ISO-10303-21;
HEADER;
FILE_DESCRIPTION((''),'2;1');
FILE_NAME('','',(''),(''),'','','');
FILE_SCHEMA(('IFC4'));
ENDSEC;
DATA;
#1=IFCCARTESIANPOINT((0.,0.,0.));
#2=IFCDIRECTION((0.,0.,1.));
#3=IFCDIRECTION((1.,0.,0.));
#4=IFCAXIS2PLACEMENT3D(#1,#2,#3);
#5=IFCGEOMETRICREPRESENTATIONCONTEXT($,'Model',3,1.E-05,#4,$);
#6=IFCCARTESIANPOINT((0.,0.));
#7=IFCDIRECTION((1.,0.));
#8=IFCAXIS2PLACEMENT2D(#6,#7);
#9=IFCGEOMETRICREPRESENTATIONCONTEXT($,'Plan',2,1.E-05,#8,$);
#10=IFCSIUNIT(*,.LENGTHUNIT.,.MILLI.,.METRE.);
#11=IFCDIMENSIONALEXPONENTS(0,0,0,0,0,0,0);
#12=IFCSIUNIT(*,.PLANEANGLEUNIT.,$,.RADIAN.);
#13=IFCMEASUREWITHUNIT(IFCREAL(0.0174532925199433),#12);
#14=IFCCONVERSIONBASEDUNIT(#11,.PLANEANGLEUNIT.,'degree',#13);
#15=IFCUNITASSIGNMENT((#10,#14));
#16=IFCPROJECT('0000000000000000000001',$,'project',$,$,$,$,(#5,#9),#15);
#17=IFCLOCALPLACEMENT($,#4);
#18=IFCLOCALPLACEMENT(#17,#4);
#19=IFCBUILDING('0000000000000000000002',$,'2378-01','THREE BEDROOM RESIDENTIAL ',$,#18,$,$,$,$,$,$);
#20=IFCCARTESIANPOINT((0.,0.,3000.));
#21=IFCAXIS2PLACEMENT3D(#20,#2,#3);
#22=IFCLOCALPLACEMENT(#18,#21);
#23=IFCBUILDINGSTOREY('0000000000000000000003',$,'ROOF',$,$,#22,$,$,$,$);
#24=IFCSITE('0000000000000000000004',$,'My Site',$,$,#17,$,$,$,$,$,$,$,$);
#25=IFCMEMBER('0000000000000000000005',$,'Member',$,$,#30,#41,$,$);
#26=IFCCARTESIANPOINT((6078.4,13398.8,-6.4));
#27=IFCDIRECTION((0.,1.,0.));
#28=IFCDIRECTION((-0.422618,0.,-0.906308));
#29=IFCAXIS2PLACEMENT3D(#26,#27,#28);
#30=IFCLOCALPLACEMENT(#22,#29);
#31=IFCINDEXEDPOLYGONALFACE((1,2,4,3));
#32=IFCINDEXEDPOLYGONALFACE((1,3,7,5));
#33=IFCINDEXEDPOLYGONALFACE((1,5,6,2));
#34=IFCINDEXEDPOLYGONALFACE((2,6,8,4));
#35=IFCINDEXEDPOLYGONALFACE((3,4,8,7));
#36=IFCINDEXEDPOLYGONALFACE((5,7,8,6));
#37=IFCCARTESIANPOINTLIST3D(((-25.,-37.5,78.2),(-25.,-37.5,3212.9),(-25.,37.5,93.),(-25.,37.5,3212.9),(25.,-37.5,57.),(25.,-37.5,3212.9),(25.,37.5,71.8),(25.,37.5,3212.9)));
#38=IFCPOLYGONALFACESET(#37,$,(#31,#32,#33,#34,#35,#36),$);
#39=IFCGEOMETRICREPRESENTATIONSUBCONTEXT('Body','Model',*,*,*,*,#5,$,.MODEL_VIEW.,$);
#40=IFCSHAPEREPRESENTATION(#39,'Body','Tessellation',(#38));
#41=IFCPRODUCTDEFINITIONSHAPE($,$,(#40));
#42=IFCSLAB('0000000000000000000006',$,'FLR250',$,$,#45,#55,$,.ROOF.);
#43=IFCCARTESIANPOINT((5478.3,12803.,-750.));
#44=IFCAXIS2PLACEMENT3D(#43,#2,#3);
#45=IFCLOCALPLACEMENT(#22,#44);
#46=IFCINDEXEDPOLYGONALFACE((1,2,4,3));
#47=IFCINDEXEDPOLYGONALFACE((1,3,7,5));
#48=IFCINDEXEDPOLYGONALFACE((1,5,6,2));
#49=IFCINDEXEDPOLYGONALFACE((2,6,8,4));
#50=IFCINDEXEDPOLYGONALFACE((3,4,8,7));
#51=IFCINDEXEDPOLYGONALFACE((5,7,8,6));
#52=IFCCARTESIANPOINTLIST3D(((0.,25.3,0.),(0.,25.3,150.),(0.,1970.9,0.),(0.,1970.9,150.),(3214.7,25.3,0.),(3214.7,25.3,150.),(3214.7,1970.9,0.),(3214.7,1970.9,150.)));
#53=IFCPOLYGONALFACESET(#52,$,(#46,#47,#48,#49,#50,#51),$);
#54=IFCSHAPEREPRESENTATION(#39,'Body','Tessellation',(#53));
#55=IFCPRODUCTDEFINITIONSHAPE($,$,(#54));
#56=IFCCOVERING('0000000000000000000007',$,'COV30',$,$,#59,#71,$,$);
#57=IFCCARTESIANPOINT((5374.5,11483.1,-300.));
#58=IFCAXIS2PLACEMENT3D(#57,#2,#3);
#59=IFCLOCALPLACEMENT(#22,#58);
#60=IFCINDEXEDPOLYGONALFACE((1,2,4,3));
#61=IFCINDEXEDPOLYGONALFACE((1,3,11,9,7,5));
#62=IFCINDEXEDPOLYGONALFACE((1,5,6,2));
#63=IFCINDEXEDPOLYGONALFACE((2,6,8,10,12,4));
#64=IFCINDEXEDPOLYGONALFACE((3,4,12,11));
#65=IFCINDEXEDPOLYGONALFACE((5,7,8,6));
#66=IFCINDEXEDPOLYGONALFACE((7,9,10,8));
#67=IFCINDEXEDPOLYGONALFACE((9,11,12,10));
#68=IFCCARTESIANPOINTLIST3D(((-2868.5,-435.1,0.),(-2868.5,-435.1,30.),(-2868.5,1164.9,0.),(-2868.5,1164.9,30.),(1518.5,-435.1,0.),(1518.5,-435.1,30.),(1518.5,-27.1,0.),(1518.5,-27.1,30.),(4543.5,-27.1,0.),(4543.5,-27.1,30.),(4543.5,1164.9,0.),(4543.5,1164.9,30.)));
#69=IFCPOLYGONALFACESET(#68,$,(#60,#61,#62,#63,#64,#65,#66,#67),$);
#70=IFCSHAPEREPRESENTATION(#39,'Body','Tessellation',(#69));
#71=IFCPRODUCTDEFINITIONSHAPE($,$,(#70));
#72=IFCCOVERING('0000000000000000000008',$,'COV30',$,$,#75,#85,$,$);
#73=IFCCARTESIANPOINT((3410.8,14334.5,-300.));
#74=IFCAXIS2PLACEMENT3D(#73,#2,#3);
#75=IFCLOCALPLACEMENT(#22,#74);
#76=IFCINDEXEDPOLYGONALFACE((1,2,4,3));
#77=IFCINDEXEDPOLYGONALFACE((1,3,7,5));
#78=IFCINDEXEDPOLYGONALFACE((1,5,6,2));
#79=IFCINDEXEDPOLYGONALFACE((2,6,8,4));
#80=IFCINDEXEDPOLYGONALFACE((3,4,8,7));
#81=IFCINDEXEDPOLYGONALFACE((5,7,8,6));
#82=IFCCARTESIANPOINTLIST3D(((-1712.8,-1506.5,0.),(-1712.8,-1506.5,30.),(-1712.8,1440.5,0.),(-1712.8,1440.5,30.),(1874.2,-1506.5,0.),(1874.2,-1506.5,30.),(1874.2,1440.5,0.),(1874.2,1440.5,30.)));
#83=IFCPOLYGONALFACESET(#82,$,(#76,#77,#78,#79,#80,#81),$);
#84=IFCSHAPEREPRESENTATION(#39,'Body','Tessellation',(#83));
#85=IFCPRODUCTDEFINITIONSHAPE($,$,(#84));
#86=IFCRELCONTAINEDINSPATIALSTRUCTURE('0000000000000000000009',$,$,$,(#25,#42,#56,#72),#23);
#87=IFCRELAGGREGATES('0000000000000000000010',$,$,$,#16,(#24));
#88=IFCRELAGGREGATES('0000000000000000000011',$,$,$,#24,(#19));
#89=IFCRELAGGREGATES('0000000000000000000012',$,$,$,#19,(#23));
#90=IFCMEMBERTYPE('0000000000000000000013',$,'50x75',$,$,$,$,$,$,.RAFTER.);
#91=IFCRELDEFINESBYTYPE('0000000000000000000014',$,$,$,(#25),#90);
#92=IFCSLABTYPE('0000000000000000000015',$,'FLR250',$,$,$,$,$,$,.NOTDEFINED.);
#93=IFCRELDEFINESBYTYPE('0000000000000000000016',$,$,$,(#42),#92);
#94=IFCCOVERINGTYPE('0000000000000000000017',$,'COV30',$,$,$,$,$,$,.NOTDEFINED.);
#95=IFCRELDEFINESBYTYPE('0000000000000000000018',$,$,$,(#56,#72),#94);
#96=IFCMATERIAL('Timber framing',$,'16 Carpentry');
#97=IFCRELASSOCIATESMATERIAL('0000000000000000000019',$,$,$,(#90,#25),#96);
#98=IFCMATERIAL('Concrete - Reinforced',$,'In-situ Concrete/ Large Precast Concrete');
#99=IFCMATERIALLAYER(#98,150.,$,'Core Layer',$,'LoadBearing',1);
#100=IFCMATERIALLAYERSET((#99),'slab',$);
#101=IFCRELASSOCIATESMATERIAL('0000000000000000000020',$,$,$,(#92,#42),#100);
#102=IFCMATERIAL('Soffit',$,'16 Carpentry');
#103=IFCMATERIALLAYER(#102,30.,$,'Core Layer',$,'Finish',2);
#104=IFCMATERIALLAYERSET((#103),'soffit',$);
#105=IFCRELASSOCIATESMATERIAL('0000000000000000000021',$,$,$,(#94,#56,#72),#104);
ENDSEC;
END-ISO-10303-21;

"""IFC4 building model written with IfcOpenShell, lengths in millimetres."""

from ifc_helpers import new_model, entity, si_unit, converted_unit, frame, origin_with_axes, origin_2d_with_axis, place, context, subcontext, project, spatial, line, indexed_curve, rectangle, outline, extrude, clip, halfspace, material, layer, layer_set, layer_usage, material_profile, profile_set, profile_usage, type_object, element, save


model = new_model("IFC4")

# Units and contexts
model_context = context("Model", 3, precision=1e-05, world=origin_with_axes())
plan_context = context("Plan", 2, precision=1e-05, world=origin_2d_with_axis())
body_context = subcontext(model_context, "Body", "Model", "MODEL_VIEW")
ifc_project = project(units=[si_unit("LENGTHUNIT", "METRE", prefix="MILLI"), converted_unit("PLANEANGLEUNIT", "degree", entity("IfcReal", 0.0174532925199433), si_unit("PLANEANGLEUNIT", "RADIAN"), dimensions=[0, 0, 0, 0, 0, 0, 0])], contexts=[model_context, plan_context])

# Site, building, storey
site_placement = place(None, origin_with_axes())
site = spatial("IfcSite", under=ifc_project, at=site_placement, Name="My Site")
building_placement = place(site_placement, origin_with_axes())
building = spatial("IfcBuilding", under=site, at=building_placement, Name="2378-01", Description="THREE BEDROOM RESIDENTIAL ")
storey_placement = place(building_placement, frame((0.0, 0.0, 3000.0), z_axis=(0.0, 0.0, 1.0), x_axis=(1.0, 0.0, 0.0)))
storey = spatial("IfcBuildingStorey", under=building, at=storey_placement, Name="ROOF")

# Member
ifc_material_1 = material(Name="Concrete - Reinforced", Category="In-situ Concrete/ Large Precast Concrete")
ifc_material_2 = material(Name="Timber framing", Category="16 Carpentry")
ifc_material_profile_1 = material_profile(ifc_material_2, rectangle(XDim=50.0, YDim=75.0), Name="Lumber2", Category="Substrate", Priority=2)
ifc_profile_set_1 = profile_set([ifc_material_profile_1])
member_type_1 = type_object("IfcMemberType", Name="50x75", PredefinedType="RAFTER", material=ifc_profile_set_1)
ifc_profile_usage_1 = profile_usage(ifc_profile_set_1, cardinal=5)
member_1_placement = place(storey_placement, frame((6078.4, 13398.8, -6.4), z_axis=(0.0, 1.0, 0.0), x_axis=(-0.422618, 0.0, -0.906308)))
element("IfcMember", 1, at=member_1_placement, inside=storey, type_object=member_type_1, material=ifc_profile_usage_1, Name="Member", context=body_context, shape_type="Clipping", body=[
    clip(extrude(rectangle(XDim=50.0, YDim=75.0), origin_with_axes(), (0.0, 0.0, 1.0), 3212.9), halfspace(frame((-801.0, -1756.5, 67.4), z_axis=(-0.383022, 0.178606, -0.906308), x_axis=(0.422618, 0.906308, 0.0)), False)),
])

# Slab
ifc_layer_1 = layer(ifc_material_1, 150.0, Name="Core Layer", Category="LoadBearing", Priority=1)
ifc_layer_set_1 = layer_set([ifc_layer_1], Name="slab")
ifc_layer_usage_1 = layer_usage(ifc_layer_set_1, "AXIS3", "POSITIVE", 0.0)
slab_type = type_object("IfcSlabType", Name="FLR250", PredefinedType="NOTDEFINED", material=ifc_layer_set_1)
slab_placement = place(storey_placement, frame((5478.3, 12803.0, -750.0), z_axis=(0.0, 0.0, 1.0), x_axis=(1.0, 0.0, 0.0)))
element("IfcSlab", 2, at=slab_placement, inside=storey, type_object=slab_type, material=ifc_layer_usage_1, Name="FLR250", PredefinedType="ROOF", context=body_context, shape_type="SweptSolid", body=[
    extrude(outline(indexed_curve([(0.0, 1970.9), (0.0, 25.3), (3214.7, 25.3), (3214.7, 1970.9)], segments=[line(3, 2), line(2, 1), line(1, 4), line(4, 3)], self_intersect=False)), None, (0.0, 0.0, 1.0), 150.0),
])

# Coverings
ifc_material_3 = material(Name="Soffit", Category="16 Carpentry")
ifc_layer_2 = layer(ifc_material_3, 30.0, Name="Core Layer", Category="Finish", Priority=2)
ifc_layer_set_2 = layer_set([ifc_layer_2], Name="soffit")
ifc_layer_usage_2 = layer_usage(ifc_layer_set_2, "AXIS3", "POSITIVE", 0.0)
covering_type_1 = type_object("IfcCoveringType", Name="COV30", PredefinedType="NOTDEFINED", material=ifc_layer_set_2)
covering_1_placement = place(storey_placement, frame((5374.5, 11483.1, -300.0), z_axis=(0.0, 0.0, 1.0), x_axis=(1.0, 0.0, 0.0)))
element("IfcCovering", 3, at=covering_1_placement, inside=storey, type_object=covering_type_1, material=ifc_layer_usage_2, Name="COV30", context=body_context, shape_type="SweptSolid", body=[
    extrude(outline(indexed_curve([(1518.5, -435.1), (-2868.5, -435.1), (-2868.5, 1164.9), (4543.5, 1164.9), (4543.5, -27.1), (1518.5, -27.1), (1518.5, -435.1)], segments=[line(1, 2, 3, 4, 5, 6, 7, 1)])), None, (0.0, 0.0, 1.0), 30.0),
])
ifc_layer_usage_3 = layer_usage(ifc_layer_set_2, "AXIS3", "POSITIVE", 0.0)
covering_2_placement = place(storey_placement, frame((3410.8, 14334.5, -300.0), z_axis=(0.0, 0.0, 1.0), x_axis=(1.0, 0.0, 0.0)))
element("IfcCovering", 4, at=covering_2_placement, inside=storey, type_object=covering_type_1, material=ifc_layer_usage_3, Name="COV30", context=body_context, shape_type="SweptSolid", body=[
    extrude(outline(indexed_curve([(-1712.8, 1440.5), (1874.2, 1440.5), (1874.2, -1506.5), (-1712.8, -1506.5), (-1712.8, 1440.5)], segments=[line(1, 2, 3, 4, 5, 1)])), None, (0.0, 0.0, 1.0), 30.0),
])

save(model, "model.ifc")
